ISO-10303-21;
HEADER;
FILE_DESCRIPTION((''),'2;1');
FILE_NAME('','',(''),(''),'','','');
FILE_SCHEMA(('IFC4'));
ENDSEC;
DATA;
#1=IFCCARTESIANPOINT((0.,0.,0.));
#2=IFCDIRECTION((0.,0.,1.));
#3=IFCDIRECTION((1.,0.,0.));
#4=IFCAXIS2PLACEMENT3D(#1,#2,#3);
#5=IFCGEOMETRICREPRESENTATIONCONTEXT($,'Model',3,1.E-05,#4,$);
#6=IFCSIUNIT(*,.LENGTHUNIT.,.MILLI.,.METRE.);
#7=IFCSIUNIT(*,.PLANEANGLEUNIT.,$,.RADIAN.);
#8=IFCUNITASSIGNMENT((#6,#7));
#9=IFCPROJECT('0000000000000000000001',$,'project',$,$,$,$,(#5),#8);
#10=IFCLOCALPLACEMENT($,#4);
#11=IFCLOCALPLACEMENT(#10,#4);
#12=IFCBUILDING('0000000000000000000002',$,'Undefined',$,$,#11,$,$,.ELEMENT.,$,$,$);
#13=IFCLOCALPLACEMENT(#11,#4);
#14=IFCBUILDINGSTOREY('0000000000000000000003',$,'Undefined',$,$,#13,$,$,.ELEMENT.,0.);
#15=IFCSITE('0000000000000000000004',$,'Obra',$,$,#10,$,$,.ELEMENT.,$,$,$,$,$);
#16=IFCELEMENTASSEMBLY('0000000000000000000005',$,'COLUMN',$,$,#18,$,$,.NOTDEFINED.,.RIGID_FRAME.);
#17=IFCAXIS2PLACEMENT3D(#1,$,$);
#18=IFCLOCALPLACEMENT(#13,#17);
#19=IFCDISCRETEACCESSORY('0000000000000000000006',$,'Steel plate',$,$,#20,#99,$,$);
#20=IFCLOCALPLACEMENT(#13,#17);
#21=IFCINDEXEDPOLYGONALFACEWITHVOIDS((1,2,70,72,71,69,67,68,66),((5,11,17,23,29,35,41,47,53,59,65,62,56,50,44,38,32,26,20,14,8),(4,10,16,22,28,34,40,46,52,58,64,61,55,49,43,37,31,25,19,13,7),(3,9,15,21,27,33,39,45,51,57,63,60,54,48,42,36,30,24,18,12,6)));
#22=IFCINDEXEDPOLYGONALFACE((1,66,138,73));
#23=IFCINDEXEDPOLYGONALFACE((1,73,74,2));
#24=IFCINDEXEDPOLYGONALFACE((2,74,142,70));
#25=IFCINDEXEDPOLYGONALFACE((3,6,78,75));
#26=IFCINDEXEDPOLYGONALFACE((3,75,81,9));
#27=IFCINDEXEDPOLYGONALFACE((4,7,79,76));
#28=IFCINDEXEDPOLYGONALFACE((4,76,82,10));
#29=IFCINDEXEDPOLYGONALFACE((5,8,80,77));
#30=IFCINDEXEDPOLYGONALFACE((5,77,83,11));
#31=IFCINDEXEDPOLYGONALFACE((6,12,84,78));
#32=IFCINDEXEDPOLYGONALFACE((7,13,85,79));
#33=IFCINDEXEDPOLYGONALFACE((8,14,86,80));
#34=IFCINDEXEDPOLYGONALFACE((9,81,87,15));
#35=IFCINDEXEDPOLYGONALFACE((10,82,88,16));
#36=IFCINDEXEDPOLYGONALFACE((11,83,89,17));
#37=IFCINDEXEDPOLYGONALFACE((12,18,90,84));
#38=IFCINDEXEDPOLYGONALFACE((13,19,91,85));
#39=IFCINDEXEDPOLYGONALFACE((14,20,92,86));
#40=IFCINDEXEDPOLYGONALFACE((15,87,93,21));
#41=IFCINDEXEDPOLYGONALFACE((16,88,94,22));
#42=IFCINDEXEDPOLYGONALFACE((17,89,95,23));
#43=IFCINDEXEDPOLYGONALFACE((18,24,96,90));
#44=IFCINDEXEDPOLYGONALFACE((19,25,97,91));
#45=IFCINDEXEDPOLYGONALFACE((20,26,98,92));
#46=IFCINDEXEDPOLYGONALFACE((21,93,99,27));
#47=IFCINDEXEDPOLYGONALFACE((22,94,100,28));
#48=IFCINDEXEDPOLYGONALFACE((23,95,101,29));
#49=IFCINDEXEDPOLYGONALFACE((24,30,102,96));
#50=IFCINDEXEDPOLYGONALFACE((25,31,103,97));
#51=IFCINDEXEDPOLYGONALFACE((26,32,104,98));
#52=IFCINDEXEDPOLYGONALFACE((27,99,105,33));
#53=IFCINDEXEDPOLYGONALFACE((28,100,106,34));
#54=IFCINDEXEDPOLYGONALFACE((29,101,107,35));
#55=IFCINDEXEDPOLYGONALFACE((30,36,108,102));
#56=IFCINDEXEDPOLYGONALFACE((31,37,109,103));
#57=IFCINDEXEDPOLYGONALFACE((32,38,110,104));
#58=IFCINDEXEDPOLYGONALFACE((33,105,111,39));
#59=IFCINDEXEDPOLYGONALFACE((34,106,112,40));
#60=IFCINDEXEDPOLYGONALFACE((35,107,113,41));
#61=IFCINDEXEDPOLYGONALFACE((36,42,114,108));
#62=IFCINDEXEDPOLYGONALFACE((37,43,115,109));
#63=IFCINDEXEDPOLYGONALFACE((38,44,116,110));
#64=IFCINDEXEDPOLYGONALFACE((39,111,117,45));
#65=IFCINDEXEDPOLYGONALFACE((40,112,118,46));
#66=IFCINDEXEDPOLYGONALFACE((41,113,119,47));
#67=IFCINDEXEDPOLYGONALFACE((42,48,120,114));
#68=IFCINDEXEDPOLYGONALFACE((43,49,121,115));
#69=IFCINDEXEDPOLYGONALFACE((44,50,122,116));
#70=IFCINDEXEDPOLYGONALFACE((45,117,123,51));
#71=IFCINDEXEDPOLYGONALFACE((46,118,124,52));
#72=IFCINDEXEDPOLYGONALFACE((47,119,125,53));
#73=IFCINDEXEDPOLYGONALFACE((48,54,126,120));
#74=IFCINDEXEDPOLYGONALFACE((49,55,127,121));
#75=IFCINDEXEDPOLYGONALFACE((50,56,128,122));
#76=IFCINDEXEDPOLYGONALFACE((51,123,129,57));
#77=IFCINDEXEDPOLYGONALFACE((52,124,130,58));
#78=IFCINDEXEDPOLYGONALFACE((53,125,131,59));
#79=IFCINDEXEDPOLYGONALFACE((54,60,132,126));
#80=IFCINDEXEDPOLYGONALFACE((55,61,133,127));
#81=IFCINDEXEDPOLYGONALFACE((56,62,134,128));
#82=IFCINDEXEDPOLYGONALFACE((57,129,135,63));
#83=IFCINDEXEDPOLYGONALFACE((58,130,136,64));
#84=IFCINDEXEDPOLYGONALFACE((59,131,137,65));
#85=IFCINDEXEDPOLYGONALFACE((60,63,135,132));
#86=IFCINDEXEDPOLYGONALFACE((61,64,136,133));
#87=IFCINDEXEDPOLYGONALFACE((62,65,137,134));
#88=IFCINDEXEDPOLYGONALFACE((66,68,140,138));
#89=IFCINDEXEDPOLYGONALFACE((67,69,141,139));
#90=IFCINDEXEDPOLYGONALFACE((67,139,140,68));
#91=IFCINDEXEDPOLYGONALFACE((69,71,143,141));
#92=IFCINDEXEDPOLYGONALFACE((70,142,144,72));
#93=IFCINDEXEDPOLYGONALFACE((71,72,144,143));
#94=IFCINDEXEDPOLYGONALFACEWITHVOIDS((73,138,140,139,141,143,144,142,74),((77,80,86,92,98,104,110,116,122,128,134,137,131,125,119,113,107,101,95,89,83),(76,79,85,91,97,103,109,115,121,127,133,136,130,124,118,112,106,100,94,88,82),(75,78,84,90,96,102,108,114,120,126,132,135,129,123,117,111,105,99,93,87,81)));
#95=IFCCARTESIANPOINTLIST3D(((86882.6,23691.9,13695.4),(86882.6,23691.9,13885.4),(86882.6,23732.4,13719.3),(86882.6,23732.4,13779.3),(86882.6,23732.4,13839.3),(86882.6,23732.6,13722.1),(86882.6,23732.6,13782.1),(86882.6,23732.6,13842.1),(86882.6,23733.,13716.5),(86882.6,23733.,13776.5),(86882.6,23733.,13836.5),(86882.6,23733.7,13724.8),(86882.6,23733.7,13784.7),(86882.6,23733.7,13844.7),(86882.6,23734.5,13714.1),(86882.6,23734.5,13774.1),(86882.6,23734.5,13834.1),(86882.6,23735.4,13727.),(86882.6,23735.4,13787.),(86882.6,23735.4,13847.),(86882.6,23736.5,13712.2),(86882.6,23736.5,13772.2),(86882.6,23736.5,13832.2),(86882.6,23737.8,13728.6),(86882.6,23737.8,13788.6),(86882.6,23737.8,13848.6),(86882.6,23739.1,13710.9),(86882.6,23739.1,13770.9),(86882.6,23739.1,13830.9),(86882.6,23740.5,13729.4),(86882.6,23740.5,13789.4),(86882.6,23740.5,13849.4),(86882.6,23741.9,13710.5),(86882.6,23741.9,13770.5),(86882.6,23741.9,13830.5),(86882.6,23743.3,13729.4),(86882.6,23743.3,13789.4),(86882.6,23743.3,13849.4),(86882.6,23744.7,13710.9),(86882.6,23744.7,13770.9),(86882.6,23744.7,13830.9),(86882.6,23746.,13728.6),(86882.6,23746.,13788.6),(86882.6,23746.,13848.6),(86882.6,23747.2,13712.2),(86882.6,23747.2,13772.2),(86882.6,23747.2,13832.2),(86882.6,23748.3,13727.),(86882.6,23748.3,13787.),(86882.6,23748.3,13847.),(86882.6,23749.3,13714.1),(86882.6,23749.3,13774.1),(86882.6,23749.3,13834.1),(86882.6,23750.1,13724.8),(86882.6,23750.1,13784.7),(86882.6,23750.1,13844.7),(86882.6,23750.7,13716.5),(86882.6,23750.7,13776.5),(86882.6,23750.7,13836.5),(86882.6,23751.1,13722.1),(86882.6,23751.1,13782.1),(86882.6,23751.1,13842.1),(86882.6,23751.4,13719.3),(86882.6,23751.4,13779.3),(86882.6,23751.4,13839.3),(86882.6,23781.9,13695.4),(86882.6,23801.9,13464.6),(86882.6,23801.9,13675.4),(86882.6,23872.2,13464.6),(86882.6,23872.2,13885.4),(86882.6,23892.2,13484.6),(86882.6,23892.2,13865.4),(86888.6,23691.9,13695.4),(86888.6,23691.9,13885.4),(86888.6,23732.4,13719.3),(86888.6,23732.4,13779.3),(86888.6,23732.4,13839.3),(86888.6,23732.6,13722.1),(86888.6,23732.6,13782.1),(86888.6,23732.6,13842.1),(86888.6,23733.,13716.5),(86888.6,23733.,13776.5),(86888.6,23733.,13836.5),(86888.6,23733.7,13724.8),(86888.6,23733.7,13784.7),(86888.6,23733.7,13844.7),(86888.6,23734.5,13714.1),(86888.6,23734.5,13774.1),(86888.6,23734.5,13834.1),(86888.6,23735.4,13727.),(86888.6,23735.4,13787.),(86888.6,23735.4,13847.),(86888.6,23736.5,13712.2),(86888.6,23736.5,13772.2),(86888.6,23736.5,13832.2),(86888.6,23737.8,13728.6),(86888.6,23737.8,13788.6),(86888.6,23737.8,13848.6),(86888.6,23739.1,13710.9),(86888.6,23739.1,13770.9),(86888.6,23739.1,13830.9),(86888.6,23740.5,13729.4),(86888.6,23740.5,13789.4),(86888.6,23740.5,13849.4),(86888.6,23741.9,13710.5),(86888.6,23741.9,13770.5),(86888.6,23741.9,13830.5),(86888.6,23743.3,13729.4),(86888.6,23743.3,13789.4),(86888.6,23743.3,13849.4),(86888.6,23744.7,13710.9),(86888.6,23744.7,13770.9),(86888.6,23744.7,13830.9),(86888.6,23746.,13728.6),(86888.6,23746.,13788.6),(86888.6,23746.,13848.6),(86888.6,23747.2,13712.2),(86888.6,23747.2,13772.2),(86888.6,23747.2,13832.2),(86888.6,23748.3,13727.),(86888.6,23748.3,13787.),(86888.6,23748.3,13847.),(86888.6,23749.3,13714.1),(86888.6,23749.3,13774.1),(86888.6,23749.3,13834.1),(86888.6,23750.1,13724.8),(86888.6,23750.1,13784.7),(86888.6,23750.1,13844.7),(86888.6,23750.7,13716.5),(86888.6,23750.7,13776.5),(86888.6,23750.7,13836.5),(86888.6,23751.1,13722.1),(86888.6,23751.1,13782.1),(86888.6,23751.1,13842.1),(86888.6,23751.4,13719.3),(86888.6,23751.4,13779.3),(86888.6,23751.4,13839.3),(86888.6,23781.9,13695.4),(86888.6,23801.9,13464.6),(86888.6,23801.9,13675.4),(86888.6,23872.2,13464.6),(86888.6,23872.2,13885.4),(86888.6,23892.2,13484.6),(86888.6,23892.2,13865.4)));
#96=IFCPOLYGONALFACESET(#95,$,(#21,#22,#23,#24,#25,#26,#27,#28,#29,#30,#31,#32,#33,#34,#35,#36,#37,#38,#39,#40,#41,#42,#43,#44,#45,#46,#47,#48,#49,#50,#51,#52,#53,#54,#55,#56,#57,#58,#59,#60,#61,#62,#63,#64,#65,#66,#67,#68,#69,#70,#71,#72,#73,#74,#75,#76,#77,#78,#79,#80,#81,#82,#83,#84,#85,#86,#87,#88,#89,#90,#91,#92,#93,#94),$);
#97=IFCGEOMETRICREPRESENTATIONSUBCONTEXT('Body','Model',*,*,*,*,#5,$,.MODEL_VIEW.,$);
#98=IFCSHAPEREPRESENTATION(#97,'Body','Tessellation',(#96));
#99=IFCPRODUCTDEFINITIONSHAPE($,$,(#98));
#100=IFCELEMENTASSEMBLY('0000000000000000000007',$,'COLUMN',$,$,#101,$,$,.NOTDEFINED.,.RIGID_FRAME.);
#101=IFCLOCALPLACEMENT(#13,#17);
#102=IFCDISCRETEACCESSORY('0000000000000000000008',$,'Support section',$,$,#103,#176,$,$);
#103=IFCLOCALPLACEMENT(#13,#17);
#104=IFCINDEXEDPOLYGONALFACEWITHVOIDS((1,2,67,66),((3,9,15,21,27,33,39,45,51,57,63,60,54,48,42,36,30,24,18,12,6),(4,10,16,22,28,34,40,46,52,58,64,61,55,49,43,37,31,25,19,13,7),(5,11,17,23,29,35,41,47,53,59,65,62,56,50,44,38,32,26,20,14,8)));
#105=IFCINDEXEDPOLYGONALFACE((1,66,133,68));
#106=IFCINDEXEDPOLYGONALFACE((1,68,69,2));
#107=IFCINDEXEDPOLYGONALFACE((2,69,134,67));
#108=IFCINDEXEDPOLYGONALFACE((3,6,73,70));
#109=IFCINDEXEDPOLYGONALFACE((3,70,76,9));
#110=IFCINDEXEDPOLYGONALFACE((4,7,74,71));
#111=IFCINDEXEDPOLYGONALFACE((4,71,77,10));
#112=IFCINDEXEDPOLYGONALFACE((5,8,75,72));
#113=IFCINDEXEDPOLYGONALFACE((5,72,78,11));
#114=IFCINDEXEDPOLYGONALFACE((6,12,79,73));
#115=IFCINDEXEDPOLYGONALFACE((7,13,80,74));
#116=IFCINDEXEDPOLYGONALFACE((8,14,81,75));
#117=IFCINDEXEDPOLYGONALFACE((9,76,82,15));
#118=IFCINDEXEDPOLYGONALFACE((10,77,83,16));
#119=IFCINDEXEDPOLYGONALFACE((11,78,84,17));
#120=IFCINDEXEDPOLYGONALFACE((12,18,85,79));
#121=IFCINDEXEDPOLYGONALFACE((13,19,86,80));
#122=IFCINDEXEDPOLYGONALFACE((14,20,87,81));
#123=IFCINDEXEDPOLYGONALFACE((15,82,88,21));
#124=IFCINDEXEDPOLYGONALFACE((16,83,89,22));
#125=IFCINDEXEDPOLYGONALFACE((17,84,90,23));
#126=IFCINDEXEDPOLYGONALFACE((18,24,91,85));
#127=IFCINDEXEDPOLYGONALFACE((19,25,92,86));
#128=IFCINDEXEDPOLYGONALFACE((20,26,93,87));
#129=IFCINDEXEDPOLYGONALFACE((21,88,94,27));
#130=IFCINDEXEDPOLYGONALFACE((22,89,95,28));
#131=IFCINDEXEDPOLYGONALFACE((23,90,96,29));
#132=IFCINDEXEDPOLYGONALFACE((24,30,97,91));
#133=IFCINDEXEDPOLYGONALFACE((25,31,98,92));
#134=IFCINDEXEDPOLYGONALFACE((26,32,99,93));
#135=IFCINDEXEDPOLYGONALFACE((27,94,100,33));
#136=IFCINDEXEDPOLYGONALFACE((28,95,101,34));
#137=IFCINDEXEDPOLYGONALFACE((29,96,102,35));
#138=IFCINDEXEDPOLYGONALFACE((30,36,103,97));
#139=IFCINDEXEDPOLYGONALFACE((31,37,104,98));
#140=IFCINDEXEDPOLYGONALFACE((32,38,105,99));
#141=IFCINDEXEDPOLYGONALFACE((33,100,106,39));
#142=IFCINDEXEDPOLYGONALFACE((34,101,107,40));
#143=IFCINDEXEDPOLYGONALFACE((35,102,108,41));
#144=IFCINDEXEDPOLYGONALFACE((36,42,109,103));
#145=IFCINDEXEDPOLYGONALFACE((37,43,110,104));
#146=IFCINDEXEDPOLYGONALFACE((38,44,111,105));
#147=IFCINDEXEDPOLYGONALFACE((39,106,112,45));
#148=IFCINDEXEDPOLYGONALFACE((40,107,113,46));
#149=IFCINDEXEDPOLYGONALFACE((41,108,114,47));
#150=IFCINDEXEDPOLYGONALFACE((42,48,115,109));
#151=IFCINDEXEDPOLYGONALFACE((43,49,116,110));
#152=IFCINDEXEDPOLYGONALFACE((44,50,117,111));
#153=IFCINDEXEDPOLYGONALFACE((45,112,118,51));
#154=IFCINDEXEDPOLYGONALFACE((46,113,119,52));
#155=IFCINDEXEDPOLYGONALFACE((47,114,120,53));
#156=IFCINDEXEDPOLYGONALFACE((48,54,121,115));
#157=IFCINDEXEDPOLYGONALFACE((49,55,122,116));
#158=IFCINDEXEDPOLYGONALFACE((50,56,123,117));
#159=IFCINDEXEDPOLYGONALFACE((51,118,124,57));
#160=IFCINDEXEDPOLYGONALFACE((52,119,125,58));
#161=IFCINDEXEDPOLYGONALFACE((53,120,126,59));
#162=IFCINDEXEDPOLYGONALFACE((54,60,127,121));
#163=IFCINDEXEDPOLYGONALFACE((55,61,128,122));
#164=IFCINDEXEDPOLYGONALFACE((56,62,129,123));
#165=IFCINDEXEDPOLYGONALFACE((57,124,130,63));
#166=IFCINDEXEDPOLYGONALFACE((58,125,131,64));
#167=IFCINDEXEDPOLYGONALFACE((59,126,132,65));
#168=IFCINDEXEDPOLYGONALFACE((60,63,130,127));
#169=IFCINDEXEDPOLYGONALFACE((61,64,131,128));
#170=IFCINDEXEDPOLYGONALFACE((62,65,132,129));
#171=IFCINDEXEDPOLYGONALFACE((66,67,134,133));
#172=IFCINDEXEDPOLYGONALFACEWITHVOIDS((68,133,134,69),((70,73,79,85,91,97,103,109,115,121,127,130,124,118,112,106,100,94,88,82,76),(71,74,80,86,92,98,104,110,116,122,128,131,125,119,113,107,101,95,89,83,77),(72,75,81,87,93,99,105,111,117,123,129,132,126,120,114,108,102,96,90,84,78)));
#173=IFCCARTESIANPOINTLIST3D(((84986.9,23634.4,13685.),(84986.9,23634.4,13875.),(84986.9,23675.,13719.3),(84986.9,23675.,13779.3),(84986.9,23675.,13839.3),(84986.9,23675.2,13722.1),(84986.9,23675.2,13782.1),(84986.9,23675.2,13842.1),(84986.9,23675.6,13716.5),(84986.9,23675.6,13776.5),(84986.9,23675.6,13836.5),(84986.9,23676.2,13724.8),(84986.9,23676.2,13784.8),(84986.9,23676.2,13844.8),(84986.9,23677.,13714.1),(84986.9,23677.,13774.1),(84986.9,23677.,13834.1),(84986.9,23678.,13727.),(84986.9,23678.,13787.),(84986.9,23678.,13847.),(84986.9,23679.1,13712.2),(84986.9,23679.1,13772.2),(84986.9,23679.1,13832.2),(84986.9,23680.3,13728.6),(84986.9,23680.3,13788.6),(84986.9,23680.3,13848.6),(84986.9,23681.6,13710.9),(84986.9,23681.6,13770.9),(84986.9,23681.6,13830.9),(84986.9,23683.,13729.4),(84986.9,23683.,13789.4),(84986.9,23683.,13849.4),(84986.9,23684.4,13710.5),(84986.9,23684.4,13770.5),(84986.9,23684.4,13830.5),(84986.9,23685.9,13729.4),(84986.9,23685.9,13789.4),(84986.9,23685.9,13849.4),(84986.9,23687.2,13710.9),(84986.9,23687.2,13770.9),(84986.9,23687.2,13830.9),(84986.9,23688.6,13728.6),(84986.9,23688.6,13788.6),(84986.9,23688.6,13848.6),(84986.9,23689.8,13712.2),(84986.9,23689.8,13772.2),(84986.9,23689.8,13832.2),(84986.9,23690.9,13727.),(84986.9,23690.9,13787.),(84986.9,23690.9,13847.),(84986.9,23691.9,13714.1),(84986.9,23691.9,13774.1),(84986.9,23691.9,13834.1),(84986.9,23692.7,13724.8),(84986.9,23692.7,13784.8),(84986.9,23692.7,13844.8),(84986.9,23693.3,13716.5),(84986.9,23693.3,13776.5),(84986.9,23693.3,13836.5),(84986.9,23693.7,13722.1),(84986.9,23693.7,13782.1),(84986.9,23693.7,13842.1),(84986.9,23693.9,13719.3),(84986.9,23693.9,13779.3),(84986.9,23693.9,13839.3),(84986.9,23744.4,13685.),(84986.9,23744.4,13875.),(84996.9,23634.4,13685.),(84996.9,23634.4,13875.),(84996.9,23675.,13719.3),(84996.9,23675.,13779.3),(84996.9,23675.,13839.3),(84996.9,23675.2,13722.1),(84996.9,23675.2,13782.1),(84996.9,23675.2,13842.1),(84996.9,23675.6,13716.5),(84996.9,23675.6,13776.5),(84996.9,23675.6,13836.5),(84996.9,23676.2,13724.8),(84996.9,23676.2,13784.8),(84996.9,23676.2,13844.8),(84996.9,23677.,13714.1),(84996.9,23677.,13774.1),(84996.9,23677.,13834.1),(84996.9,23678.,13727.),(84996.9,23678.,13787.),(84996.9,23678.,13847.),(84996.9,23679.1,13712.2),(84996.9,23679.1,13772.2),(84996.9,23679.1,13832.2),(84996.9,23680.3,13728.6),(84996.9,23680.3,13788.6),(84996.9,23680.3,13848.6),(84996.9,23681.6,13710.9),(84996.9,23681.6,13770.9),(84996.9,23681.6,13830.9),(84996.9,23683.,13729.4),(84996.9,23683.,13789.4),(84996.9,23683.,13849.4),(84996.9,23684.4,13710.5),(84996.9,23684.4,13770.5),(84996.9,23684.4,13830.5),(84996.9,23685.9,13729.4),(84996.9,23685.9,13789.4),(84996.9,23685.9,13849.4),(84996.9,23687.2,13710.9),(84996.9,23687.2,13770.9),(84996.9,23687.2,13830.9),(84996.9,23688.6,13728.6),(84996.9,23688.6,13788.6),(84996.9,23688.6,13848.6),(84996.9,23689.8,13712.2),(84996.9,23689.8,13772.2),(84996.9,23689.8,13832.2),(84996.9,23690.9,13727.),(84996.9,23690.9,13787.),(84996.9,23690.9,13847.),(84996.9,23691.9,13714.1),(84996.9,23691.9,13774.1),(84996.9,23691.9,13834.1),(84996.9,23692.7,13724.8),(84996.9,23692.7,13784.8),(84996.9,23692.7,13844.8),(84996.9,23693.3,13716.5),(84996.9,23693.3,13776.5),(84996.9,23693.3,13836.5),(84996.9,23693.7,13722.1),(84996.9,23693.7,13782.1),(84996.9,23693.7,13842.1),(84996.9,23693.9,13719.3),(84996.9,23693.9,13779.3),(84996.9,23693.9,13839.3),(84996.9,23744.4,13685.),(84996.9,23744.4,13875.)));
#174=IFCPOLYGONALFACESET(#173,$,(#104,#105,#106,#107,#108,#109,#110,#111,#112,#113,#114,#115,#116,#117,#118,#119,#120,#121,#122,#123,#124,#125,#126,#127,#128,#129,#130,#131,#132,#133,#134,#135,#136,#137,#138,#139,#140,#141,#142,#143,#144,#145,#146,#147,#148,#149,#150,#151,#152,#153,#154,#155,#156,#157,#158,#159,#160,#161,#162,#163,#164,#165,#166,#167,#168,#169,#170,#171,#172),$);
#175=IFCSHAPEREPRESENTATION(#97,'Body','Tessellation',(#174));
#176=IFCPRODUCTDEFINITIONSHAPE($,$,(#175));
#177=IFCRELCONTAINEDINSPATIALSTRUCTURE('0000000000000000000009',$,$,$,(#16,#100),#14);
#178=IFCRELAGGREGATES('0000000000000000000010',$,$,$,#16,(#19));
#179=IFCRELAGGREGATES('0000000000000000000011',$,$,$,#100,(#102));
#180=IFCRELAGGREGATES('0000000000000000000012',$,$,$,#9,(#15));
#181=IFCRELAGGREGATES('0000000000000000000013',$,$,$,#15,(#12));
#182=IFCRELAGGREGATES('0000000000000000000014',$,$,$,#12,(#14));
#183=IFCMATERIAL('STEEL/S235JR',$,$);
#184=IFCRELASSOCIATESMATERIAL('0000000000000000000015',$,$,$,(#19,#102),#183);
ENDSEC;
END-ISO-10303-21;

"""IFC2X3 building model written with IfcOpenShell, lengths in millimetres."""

from ifc_helpers import new_model, si_unit, frame, origin_with_axes, origin_2d_with_axis, place, context, subcontext, project, spatial, polyline, rectangle, circle, outline, extrude, source, transform, mapped, material, element, aggregate, save


model = new_model("IFC2X3")

# Units and contexts
model_context = context("Model", 3, precision=1e-05, world=origin_with_axes())
body_context = subcontext(model_context, "Body", "Model", "MODEL_VIEW")
ifc_project = project(units=[si_unit("LENGTHUNIT", "METRE", prefix="MILLI"), si_unit("PLANEANGLEUNIT", "RADIAN")], contexts=[model_context])

# Site, building, storey
site_placement = place(None, origin_with_axes())
site = spatial("IfcSite", under=ifc_project, at=site_placement, Name="Obra", CompositionType="ELEMENT")
building_placement = place(site_placement, origin_with_axes())
building = spatial("IfcBuilding", under=site, at=building_placement, Name="Undefined", CompositionType="ELEMENT")
storey_placement = place(building_placement, origin_with_axes())
storey = spatial("IfcBuildingStorey", under=building, at=storey_placement, Name="Undefined", CompositionType="ELEMENT", Elevation=0.0)

# Shared definitions
ifc_material_1 = material(Name="STEEL/S235JR")

# Element assembly, discrete accessory, opening
assembly_1_placement = place(storey_placement, origin_with_axes())
assembly_1 = element("IfcElementAssembly", 1, at=assembly_1_placement, inside=storey, Name="COLUMN", AssemblyPlace="NOTDEFINED", PredefinedType="RIGID_FRAME")
discrete_accessory_1_placement = place(assembly_1_placement, frame((86885.6, 23892.2, 13484.6), z_axis=(-1.0, 0.0, 0.0), x_axis=(0.0, -0.707107, -0.707107)))
discrete_accessory_1 = element("IfcDiscreteAccessory", 2, at=discrete_accessory_1_placement, material=ifc_material_1, Name="Steel plate", context=body_context, shape_type="SweptSolid", body=[
    extrude(outline(polyline([(0.0, 0.0), (28.3, 0.0), (78.0, 49.7), (-71.1, 198.8), (-71.1, 227.1), (-7.4, 290.7), (-141.8, 425.0), (-269.3, 297.6), (-269.3, 269.3), (0.0, 0.0)])), frame((0.0, 0.0, -3.0), z_axis=(0.0, 0.0, 1.0), x_axis=(1.0, 0.0, 0.0)), (0.0, 0.0, 1.0), 6.0),
])
shared_shape_1 = source(origin_with_axes(), body_context, "Body", "SweptSolid", [
    extrude(circle(Radius=9.5, at=origin_2d_with_axis()), frame((0.0, -9.2, 0.0), z_axis=(0.0, 1.0, 0.0), x_axis=(1.0, 0.0, 0.0)), (0.0, 0.0, 1.0), 6.2),
])
opening_1_placement = place(assembly_1_placement, frame((86891.7, 23791.9, 13885.4), z_axis=(0.0, -1.0, 0.0), x_axis=(0.0, 0.0, -1.0)))
element("IfcOpeningElement", 3, at=opening_1_placement, cuts=discrete_accessory_1, ObjectType="Opening", context=body_context, shape_type="MappedRepresentation", body=[
    mapped(shared_shape_1, transform((165.4, 0.0, 50.0))),
    mapped(shared_shape_1, transform((105.4, 0.0, 50.0))),
    mapped(shared_shape_1, transform((45.4, 0.0, 50.0))),
])

# Element assembly, discrete accessory, opening
assembly_2_placement = place(storey_placement, origin_with_axes())
assembly_2 = element("IfcElementAssembly", 4, at=assembly_2_placement, inside=storey, Name="COLUMN", AssemblyPlace="NOTDEFINED", PredefinedType="RIGID_FRAME")
discrete_accessory_2_placement = place(assembly_2_placement, frame((84991.9, 23689.4, 13685.0), z_axis=(0.0, 0.0, 1.0), x_axis=(0.0, 1.0, 0.0)))
discrete_accessory_2 = element("IfcDiscreteAccessory", 5, at=discrete_accessory_2_placement, material=ifc_material_1, Name="Support section", context=body_context, shape_type="SweptSolid", body=[
    extrude(rectangle(XDim=10.0, YDim=110.0, at=origin_2d_with_axis()), frame((0.0, 0.0, 190.0), z_axis=(0.0, 0.0, -1.0), x_axis=(0.0, 1.0, 0.0)), (0.0, 0.0, 1.0), 190.0),
])
shared_shape_2 = source(origin_with_axes(), body_context, "Body", "SweptSolid", [
    extrude(circle(Radius=9.5, at=origin_2d_with_axis()), frame((0.0, -13.2, 0.0), z_axis=(0.0, 1.0, 0.0), x_axis=(1.0, 0.0, 0.0)), (0.0, 0.0, 1.0), 10.2),
])
opening_2_placement = place(assembly_2_placement, frame((85000.0, 23734.4, 13900.0), z_axis=(0.0, -1.0, 0.0), x_axis=(0.0, 0.0, -1.0)))
element("IfcOpeningElement", 6, at=opening_2_placement, cuts=discrete_accessory_2, ObjectType="Opening", context=body_context, shape_type="MappedRepresentation", body=[
    mapped(shared_shape_2, transform((60.0, 0.0, 50.0))),
    mapped(shared_shape_2, transform((120.0, 0.0, 50.0))),
    mapped(shared_shape_2, transform((180.0, 0.0, 50.0))),
])

aggregate(assembly_1, [discrete_accessory_1])

aggregate(assembly_2, [discrete_accessory_2])

save(model, "model.ifc")
